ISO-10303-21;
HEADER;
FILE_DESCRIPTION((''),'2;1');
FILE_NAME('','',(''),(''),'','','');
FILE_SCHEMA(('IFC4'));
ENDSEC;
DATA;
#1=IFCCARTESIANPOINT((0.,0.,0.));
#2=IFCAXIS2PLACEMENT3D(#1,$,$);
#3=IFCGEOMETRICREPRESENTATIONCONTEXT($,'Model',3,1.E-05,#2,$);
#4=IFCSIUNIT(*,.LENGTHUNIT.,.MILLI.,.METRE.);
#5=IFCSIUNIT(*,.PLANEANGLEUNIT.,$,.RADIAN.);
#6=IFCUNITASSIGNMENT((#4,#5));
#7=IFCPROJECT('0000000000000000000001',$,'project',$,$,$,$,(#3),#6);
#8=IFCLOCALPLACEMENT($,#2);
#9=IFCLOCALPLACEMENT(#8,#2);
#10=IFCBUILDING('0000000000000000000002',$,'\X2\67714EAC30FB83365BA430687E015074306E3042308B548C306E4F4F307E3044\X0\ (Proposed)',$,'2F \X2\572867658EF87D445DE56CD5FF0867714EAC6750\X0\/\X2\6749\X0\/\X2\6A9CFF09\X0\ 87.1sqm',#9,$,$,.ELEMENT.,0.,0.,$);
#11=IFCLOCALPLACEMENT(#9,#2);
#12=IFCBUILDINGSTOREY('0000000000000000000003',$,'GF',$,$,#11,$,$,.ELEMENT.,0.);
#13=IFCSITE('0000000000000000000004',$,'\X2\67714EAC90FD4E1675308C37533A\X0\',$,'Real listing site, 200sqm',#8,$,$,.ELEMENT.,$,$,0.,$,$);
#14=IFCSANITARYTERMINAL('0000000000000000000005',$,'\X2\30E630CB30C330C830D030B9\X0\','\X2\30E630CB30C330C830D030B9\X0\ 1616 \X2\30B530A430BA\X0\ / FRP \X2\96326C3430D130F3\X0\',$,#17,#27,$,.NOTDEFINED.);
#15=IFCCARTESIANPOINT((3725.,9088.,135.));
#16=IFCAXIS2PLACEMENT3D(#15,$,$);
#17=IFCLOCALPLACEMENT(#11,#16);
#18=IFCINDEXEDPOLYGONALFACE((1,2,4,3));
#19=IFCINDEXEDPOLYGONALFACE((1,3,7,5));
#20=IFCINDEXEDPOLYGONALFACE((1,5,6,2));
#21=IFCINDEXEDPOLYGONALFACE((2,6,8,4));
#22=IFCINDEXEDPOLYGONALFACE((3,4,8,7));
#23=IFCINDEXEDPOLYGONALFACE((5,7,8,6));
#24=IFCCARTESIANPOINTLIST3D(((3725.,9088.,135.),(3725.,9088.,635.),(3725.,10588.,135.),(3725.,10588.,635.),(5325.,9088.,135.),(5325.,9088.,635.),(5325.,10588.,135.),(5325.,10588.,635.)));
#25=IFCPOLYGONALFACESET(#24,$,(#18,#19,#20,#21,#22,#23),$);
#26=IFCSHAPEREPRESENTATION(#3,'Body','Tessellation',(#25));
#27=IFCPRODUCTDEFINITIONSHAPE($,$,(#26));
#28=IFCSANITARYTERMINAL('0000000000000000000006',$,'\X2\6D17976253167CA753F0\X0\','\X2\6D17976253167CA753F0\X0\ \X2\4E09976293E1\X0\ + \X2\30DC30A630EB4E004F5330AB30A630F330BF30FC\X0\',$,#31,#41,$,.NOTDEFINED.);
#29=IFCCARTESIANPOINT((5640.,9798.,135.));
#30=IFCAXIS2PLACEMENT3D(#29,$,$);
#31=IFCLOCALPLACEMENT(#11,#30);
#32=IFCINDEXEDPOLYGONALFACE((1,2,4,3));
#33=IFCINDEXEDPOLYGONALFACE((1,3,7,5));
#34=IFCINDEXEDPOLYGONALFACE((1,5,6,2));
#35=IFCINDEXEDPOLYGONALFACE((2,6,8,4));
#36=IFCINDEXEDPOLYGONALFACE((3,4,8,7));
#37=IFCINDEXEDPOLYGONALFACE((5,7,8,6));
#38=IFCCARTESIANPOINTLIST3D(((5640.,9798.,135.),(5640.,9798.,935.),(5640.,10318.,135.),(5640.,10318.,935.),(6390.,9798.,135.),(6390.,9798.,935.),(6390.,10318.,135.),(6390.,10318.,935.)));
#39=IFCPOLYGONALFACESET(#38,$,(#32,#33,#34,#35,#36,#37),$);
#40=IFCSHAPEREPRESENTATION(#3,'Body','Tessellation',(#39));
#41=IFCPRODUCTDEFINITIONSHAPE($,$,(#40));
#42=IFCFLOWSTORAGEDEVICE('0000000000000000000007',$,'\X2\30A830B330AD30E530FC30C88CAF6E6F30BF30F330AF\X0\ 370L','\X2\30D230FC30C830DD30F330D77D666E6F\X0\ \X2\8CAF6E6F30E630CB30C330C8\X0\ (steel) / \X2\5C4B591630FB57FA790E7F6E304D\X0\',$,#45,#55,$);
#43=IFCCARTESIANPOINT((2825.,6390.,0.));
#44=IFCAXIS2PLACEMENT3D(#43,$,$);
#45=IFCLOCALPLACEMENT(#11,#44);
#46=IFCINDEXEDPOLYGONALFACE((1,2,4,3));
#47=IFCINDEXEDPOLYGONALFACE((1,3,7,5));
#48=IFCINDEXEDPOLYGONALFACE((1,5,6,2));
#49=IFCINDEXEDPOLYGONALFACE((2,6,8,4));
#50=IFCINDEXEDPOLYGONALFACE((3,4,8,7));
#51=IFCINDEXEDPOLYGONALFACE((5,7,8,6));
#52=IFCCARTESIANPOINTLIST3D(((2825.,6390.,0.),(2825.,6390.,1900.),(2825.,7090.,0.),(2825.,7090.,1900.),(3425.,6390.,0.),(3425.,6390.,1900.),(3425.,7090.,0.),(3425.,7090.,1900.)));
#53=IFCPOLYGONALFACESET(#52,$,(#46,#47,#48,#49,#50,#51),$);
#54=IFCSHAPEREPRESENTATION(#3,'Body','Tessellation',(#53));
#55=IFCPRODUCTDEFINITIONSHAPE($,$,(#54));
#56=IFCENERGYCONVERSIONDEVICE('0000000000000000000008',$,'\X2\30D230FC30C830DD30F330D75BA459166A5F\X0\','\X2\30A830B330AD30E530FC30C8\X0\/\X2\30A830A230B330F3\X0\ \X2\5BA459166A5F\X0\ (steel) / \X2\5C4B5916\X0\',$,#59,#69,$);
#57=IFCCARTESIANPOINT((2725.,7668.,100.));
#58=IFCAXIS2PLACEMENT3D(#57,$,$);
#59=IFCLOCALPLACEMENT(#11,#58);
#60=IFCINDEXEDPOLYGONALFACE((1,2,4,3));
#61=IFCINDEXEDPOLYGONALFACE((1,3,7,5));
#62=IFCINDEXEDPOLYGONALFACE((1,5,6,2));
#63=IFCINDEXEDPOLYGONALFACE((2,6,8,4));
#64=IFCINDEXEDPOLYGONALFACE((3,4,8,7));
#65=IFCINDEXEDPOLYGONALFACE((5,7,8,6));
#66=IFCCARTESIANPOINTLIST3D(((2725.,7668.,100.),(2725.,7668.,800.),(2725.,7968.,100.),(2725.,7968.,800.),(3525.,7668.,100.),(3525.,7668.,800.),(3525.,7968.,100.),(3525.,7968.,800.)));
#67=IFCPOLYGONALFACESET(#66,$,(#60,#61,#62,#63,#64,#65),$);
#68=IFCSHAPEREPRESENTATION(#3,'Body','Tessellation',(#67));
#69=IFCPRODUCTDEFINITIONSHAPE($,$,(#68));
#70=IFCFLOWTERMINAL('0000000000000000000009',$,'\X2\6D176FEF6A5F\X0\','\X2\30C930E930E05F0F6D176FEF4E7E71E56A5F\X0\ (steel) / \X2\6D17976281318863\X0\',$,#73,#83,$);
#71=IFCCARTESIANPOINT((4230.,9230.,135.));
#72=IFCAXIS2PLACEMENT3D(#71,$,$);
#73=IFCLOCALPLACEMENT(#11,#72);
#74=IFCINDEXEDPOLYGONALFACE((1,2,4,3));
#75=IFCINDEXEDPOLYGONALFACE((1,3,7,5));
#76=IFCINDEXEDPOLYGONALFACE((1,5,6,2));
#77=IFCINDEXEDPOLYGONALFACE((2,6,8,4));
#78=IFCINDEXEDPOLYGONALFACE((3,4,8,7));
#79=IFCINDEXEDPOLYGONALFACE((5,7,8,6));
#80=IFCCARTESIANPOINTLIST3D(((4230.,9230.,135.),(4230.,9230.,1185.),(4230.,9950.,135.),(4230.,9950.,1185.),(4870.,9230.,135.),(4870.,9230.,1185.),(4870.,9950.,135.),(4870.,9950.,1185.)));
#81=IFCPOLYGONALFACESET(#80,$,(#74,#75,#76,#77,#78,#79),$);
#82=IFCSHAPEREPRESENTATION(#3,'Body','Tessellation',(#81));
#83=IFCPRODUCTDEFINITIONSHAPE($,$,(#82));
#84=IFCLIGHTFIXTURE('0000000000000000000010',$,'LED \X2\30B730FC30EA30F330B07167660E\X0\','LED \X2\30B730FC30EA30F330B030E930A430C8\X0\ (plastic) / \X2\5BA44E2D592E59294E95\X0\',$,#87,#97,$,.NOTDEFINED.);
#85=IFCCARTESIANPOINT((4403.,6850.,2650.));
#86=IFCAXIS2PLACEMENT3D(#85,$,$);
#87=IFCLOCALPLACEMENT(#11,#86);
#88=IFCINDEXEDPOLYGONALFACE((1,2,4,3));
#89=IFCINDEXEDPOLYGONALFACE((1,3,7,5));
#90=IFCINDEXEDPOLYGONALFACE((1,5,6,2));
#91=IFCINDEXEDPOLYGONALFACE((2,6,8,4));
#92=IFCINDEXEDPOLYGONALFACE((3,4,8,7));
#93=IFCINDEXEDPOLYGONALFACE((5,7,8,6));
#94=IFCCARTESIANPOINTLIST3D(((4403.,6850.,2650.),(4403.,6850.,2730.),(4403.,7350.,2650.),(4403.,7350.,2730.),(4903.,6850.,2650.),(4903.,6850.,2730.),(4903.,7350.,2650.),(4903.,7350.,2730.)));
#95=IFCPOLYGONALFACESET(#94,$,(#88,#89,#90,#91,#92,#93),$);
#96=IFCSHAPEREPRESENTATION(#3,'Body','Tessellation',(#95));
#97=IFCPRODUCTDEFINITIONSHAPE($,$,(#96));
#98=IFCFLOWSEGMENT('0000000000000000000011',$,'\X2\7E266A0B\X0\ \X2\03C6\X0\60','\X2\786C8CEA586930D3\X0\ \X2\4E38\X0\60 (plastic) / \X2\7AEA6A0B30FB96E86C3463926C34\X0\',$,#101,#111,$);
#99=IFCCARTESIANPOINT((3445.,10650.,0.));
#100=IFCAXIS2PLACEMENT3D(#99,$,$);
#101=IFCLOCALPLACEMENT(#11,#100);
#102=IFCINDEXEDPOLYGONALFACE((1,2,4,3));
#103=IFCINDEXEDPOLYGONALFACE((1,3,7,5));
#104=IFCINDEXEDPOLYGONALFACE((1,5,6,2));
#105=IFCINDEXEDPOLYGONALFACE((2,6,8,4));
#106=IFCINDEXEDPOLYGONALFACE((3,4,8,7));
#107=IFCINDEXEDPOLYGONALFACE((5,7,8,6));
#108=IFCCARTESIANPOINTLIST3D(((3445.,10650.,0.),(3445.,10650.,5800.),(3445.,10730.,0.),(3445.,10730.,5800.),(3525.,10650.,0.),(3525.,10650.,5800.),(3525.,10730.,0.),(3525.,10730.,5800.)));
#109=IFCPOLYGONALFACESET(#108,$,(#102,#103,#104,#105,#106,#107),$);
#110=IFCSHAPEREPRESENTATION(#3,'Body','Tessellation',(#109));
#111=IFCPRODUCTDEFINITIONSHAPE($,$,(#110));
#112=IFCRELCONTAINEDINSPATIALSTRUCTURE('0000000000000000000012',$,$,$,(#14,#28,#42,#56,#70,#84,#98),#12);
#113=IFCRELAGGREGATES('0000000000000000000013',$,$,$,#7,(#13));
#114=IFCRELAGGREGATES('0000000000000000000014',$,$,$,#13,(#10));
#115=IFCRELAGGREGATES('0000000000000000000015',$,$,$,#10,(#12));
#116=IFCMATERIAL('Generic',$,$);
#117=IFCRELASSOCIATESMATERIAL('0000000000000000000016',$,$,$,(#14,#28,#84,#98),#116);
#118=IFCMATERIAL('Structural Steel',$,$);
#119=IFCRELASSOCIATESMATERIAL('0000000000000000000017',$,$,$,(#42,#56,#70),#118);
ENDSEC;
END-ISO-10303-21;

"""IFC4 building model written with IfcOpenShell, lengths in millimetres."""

from ifc_helpers import new_model, si_unit, frame, frame_2d, origin, place, context, project, spatial, rectangle, extrude, material, element, save


model = new_model("IFC4")

# Units and contexts
model_context = context("Model", 3, precision=1e-05, world=origin())
ifc_project = project(units=[si_unit("LENGTHUNIT", "METRE", prefix="MILLI"), si_unit("PLANEANGLEUNIT", "RADIAN")], contexts=[model_context])

# Site, building, storey
site_placement = place(None, origin())
site = spatial("IfcSite", under=ifc_project, at=site_placement, Name="東京都世田谷区", ObjectType="Real listing site, 200sqm", CompositionType="ELEMENT", RefElevation=0.0)
building_placement = place(site_placement, origin())
building = spatial("IfcBuilding", under=site, at=building_placement, Name="東京・茶室と縁側のある和の住まい (Proposed)", ObjectType="2F 在来軸組工法（東京材/杉/檜） 87.1sqm", CompositionType="ELEMENT", ElevationOfRefHeight=0.0, ElevationOfTerrain=0.0)
storey_placement = place(building_placement, origin())
storey = spatial("IfcBuildingStorey", under=building, at=storey_placement, Name="GF", CompositionType="ELEMENT", Elevation=0.0)

# Shared definitions
ifc_material_1 = material(Name="Generic")

# Sanitary terminals
sanitary_terminal_1_placement = place(storey_placement, frame((3725.0, 9088.0, 135.0)))
element("IfcSanitaryTerminal", 1, at=sanitary_terminal_1_placement, inside=storey, material=ifc_material_1, Name="ユニットバス", Description="ユニットバス 1616 サイズ / FRP 防水パン", PredefinedType="NOTDEFINED", context=model_context, shape_type="SweptSolid", body=[
    extrude(rectangle(XDim=1600.0, YDim=1500.0, at=frame_2d((800.0, 750.0))), frame((3725.0, 9088.0, 135.0)), (0.0, 0.0, 1.0), 500.0),
])
sanitary_terminal_2_placement = place(storey_placement, frame((5640.0, 9798.0, 135.0)))
element("IfcSanitaryTerminal", 2, at=sanitary_terminal_2_placement, inside=storey, material=ifc_material_1, Name="洗面化粧台", Description="洗面化粧台 三面鏡 + ボウル一体カウンター", PredefinedType="NOTDEFINED", context=model_context, shape_type="SweptSolid", body=[
    extrude(rectangle(XDim=750.0, YDim=520.0, at=frame_2d((375.0, 260.0))), frame((5640.0, 9798.0, 135.0)), (0.0, 0.0, 1.0), 800.0),
])

# Flow storage device
ifc_material_2 = material(Name="Structural Steel")
flow_storage_device_placement = place(storey_placement, frame((2825.0, 6390.0, 0.0)))
element("IfcFlowStorageDevice", 3, at=flow_storage_device_placement, inside=storey, material=ifc_material_2, Name="エコキュート貯湯タンク 370L", Description="ヒートポンプ給湯 貯湯ユニット (steel) / 屋外・基礎置き", context=model_context, shape_type="SweptSolid", body=[
    extrude(rectangle(XDim=600.0, YDim=700.0, at=frame_2d((300.0, 350.0))), frame((2825.0, 6390.0, 0.0)), (0.0, 0.0, 1.0), 1900.0),
])

# Energy conversion device
energy_conversion_device_placement = place(storey_placement, frame((2725.0, 7668.0, 100.0)))
element("IfcEnergyConversionDevice", 4, at=energy_conversion_device_placement, inside=storey, material=ifc_material_2, Name="ヒートポンプ室外機", Description="エコキュート/エアコン 室外機 (steel) / 屋外", context=model_context, shape_type="SweptSolid", body=[
    extrude(rectangle(XDim=800.0, YDim=300.0, at=frame_2d((400.0, 150.0))), frame((2725.0, 7668.0, 100.0)), (0.0, 0.0, 1.0), 700.0),
])

# Flow terminal
flow_terminal_placement = place(storey_placement, frame((4230.0, 9230.0, 135.0)))
element("IfcFlowTerminal", 5, at=flow_terminal_placement, inside=storey, material=ifc_material_2, Name="洗濯機", Description="ドラム式洗濯乾燥機 (steel) / 洗面脱衣", context=model_context, shape_type="SweptSolid", body=[
    extrude(rectangle(XDim=640.0, YDim=720.0, at=frame_2d((320.0, 360.0))), frame((4230.0, 9230.0, 135.0)), (0.0, 0.0, 1.0), 1050.0),
])

# Light fixture
light_fixture_placement = place(storey_placement, frame((4403.0, 6850.0, 2650.0)))
element("IfcLightFixture", 6, at=light_fixture_placement, inside=storey, material=ifc_material_1, Name="LED シーリング照明", Description="LED シーリングライト (plastic) / 室中央天井", PredefinedType="NOTDEFINED", context=model_context, shape_type="SweptSolid", body=[
    extrude(rectangle(XDim=500.0, YDim=500.0, at=frame_2d((250.0, 250.0))), frame((4403.0, 6850.0, 2650.0)), (0.0, 0.0, 1.0), 80.0),
])

# Flow segment
flow_segment_placement = place(storey_placement, frame((3445.0, 10650.0, 0.0)))
element("IfcFlowSegment", 7, at=flow_segment_placement, inside=storey, material=ifc_material_1, Name="縦樋 φ60", Description="硬質塩ビ 丸60 (plastic) / 竪樋・雨水排水", context=model_context, shape_type="SweptSolid", body=[
    extrude(rectangle(XDim=80.0, YDim=80.0, at=frame_2d((40.0, 40.0))), frame((3445.0, 10650.0, 0.0)), (0.0, 0.0, 1.0), 5800.0),
])

save(model, "model.ifc")
